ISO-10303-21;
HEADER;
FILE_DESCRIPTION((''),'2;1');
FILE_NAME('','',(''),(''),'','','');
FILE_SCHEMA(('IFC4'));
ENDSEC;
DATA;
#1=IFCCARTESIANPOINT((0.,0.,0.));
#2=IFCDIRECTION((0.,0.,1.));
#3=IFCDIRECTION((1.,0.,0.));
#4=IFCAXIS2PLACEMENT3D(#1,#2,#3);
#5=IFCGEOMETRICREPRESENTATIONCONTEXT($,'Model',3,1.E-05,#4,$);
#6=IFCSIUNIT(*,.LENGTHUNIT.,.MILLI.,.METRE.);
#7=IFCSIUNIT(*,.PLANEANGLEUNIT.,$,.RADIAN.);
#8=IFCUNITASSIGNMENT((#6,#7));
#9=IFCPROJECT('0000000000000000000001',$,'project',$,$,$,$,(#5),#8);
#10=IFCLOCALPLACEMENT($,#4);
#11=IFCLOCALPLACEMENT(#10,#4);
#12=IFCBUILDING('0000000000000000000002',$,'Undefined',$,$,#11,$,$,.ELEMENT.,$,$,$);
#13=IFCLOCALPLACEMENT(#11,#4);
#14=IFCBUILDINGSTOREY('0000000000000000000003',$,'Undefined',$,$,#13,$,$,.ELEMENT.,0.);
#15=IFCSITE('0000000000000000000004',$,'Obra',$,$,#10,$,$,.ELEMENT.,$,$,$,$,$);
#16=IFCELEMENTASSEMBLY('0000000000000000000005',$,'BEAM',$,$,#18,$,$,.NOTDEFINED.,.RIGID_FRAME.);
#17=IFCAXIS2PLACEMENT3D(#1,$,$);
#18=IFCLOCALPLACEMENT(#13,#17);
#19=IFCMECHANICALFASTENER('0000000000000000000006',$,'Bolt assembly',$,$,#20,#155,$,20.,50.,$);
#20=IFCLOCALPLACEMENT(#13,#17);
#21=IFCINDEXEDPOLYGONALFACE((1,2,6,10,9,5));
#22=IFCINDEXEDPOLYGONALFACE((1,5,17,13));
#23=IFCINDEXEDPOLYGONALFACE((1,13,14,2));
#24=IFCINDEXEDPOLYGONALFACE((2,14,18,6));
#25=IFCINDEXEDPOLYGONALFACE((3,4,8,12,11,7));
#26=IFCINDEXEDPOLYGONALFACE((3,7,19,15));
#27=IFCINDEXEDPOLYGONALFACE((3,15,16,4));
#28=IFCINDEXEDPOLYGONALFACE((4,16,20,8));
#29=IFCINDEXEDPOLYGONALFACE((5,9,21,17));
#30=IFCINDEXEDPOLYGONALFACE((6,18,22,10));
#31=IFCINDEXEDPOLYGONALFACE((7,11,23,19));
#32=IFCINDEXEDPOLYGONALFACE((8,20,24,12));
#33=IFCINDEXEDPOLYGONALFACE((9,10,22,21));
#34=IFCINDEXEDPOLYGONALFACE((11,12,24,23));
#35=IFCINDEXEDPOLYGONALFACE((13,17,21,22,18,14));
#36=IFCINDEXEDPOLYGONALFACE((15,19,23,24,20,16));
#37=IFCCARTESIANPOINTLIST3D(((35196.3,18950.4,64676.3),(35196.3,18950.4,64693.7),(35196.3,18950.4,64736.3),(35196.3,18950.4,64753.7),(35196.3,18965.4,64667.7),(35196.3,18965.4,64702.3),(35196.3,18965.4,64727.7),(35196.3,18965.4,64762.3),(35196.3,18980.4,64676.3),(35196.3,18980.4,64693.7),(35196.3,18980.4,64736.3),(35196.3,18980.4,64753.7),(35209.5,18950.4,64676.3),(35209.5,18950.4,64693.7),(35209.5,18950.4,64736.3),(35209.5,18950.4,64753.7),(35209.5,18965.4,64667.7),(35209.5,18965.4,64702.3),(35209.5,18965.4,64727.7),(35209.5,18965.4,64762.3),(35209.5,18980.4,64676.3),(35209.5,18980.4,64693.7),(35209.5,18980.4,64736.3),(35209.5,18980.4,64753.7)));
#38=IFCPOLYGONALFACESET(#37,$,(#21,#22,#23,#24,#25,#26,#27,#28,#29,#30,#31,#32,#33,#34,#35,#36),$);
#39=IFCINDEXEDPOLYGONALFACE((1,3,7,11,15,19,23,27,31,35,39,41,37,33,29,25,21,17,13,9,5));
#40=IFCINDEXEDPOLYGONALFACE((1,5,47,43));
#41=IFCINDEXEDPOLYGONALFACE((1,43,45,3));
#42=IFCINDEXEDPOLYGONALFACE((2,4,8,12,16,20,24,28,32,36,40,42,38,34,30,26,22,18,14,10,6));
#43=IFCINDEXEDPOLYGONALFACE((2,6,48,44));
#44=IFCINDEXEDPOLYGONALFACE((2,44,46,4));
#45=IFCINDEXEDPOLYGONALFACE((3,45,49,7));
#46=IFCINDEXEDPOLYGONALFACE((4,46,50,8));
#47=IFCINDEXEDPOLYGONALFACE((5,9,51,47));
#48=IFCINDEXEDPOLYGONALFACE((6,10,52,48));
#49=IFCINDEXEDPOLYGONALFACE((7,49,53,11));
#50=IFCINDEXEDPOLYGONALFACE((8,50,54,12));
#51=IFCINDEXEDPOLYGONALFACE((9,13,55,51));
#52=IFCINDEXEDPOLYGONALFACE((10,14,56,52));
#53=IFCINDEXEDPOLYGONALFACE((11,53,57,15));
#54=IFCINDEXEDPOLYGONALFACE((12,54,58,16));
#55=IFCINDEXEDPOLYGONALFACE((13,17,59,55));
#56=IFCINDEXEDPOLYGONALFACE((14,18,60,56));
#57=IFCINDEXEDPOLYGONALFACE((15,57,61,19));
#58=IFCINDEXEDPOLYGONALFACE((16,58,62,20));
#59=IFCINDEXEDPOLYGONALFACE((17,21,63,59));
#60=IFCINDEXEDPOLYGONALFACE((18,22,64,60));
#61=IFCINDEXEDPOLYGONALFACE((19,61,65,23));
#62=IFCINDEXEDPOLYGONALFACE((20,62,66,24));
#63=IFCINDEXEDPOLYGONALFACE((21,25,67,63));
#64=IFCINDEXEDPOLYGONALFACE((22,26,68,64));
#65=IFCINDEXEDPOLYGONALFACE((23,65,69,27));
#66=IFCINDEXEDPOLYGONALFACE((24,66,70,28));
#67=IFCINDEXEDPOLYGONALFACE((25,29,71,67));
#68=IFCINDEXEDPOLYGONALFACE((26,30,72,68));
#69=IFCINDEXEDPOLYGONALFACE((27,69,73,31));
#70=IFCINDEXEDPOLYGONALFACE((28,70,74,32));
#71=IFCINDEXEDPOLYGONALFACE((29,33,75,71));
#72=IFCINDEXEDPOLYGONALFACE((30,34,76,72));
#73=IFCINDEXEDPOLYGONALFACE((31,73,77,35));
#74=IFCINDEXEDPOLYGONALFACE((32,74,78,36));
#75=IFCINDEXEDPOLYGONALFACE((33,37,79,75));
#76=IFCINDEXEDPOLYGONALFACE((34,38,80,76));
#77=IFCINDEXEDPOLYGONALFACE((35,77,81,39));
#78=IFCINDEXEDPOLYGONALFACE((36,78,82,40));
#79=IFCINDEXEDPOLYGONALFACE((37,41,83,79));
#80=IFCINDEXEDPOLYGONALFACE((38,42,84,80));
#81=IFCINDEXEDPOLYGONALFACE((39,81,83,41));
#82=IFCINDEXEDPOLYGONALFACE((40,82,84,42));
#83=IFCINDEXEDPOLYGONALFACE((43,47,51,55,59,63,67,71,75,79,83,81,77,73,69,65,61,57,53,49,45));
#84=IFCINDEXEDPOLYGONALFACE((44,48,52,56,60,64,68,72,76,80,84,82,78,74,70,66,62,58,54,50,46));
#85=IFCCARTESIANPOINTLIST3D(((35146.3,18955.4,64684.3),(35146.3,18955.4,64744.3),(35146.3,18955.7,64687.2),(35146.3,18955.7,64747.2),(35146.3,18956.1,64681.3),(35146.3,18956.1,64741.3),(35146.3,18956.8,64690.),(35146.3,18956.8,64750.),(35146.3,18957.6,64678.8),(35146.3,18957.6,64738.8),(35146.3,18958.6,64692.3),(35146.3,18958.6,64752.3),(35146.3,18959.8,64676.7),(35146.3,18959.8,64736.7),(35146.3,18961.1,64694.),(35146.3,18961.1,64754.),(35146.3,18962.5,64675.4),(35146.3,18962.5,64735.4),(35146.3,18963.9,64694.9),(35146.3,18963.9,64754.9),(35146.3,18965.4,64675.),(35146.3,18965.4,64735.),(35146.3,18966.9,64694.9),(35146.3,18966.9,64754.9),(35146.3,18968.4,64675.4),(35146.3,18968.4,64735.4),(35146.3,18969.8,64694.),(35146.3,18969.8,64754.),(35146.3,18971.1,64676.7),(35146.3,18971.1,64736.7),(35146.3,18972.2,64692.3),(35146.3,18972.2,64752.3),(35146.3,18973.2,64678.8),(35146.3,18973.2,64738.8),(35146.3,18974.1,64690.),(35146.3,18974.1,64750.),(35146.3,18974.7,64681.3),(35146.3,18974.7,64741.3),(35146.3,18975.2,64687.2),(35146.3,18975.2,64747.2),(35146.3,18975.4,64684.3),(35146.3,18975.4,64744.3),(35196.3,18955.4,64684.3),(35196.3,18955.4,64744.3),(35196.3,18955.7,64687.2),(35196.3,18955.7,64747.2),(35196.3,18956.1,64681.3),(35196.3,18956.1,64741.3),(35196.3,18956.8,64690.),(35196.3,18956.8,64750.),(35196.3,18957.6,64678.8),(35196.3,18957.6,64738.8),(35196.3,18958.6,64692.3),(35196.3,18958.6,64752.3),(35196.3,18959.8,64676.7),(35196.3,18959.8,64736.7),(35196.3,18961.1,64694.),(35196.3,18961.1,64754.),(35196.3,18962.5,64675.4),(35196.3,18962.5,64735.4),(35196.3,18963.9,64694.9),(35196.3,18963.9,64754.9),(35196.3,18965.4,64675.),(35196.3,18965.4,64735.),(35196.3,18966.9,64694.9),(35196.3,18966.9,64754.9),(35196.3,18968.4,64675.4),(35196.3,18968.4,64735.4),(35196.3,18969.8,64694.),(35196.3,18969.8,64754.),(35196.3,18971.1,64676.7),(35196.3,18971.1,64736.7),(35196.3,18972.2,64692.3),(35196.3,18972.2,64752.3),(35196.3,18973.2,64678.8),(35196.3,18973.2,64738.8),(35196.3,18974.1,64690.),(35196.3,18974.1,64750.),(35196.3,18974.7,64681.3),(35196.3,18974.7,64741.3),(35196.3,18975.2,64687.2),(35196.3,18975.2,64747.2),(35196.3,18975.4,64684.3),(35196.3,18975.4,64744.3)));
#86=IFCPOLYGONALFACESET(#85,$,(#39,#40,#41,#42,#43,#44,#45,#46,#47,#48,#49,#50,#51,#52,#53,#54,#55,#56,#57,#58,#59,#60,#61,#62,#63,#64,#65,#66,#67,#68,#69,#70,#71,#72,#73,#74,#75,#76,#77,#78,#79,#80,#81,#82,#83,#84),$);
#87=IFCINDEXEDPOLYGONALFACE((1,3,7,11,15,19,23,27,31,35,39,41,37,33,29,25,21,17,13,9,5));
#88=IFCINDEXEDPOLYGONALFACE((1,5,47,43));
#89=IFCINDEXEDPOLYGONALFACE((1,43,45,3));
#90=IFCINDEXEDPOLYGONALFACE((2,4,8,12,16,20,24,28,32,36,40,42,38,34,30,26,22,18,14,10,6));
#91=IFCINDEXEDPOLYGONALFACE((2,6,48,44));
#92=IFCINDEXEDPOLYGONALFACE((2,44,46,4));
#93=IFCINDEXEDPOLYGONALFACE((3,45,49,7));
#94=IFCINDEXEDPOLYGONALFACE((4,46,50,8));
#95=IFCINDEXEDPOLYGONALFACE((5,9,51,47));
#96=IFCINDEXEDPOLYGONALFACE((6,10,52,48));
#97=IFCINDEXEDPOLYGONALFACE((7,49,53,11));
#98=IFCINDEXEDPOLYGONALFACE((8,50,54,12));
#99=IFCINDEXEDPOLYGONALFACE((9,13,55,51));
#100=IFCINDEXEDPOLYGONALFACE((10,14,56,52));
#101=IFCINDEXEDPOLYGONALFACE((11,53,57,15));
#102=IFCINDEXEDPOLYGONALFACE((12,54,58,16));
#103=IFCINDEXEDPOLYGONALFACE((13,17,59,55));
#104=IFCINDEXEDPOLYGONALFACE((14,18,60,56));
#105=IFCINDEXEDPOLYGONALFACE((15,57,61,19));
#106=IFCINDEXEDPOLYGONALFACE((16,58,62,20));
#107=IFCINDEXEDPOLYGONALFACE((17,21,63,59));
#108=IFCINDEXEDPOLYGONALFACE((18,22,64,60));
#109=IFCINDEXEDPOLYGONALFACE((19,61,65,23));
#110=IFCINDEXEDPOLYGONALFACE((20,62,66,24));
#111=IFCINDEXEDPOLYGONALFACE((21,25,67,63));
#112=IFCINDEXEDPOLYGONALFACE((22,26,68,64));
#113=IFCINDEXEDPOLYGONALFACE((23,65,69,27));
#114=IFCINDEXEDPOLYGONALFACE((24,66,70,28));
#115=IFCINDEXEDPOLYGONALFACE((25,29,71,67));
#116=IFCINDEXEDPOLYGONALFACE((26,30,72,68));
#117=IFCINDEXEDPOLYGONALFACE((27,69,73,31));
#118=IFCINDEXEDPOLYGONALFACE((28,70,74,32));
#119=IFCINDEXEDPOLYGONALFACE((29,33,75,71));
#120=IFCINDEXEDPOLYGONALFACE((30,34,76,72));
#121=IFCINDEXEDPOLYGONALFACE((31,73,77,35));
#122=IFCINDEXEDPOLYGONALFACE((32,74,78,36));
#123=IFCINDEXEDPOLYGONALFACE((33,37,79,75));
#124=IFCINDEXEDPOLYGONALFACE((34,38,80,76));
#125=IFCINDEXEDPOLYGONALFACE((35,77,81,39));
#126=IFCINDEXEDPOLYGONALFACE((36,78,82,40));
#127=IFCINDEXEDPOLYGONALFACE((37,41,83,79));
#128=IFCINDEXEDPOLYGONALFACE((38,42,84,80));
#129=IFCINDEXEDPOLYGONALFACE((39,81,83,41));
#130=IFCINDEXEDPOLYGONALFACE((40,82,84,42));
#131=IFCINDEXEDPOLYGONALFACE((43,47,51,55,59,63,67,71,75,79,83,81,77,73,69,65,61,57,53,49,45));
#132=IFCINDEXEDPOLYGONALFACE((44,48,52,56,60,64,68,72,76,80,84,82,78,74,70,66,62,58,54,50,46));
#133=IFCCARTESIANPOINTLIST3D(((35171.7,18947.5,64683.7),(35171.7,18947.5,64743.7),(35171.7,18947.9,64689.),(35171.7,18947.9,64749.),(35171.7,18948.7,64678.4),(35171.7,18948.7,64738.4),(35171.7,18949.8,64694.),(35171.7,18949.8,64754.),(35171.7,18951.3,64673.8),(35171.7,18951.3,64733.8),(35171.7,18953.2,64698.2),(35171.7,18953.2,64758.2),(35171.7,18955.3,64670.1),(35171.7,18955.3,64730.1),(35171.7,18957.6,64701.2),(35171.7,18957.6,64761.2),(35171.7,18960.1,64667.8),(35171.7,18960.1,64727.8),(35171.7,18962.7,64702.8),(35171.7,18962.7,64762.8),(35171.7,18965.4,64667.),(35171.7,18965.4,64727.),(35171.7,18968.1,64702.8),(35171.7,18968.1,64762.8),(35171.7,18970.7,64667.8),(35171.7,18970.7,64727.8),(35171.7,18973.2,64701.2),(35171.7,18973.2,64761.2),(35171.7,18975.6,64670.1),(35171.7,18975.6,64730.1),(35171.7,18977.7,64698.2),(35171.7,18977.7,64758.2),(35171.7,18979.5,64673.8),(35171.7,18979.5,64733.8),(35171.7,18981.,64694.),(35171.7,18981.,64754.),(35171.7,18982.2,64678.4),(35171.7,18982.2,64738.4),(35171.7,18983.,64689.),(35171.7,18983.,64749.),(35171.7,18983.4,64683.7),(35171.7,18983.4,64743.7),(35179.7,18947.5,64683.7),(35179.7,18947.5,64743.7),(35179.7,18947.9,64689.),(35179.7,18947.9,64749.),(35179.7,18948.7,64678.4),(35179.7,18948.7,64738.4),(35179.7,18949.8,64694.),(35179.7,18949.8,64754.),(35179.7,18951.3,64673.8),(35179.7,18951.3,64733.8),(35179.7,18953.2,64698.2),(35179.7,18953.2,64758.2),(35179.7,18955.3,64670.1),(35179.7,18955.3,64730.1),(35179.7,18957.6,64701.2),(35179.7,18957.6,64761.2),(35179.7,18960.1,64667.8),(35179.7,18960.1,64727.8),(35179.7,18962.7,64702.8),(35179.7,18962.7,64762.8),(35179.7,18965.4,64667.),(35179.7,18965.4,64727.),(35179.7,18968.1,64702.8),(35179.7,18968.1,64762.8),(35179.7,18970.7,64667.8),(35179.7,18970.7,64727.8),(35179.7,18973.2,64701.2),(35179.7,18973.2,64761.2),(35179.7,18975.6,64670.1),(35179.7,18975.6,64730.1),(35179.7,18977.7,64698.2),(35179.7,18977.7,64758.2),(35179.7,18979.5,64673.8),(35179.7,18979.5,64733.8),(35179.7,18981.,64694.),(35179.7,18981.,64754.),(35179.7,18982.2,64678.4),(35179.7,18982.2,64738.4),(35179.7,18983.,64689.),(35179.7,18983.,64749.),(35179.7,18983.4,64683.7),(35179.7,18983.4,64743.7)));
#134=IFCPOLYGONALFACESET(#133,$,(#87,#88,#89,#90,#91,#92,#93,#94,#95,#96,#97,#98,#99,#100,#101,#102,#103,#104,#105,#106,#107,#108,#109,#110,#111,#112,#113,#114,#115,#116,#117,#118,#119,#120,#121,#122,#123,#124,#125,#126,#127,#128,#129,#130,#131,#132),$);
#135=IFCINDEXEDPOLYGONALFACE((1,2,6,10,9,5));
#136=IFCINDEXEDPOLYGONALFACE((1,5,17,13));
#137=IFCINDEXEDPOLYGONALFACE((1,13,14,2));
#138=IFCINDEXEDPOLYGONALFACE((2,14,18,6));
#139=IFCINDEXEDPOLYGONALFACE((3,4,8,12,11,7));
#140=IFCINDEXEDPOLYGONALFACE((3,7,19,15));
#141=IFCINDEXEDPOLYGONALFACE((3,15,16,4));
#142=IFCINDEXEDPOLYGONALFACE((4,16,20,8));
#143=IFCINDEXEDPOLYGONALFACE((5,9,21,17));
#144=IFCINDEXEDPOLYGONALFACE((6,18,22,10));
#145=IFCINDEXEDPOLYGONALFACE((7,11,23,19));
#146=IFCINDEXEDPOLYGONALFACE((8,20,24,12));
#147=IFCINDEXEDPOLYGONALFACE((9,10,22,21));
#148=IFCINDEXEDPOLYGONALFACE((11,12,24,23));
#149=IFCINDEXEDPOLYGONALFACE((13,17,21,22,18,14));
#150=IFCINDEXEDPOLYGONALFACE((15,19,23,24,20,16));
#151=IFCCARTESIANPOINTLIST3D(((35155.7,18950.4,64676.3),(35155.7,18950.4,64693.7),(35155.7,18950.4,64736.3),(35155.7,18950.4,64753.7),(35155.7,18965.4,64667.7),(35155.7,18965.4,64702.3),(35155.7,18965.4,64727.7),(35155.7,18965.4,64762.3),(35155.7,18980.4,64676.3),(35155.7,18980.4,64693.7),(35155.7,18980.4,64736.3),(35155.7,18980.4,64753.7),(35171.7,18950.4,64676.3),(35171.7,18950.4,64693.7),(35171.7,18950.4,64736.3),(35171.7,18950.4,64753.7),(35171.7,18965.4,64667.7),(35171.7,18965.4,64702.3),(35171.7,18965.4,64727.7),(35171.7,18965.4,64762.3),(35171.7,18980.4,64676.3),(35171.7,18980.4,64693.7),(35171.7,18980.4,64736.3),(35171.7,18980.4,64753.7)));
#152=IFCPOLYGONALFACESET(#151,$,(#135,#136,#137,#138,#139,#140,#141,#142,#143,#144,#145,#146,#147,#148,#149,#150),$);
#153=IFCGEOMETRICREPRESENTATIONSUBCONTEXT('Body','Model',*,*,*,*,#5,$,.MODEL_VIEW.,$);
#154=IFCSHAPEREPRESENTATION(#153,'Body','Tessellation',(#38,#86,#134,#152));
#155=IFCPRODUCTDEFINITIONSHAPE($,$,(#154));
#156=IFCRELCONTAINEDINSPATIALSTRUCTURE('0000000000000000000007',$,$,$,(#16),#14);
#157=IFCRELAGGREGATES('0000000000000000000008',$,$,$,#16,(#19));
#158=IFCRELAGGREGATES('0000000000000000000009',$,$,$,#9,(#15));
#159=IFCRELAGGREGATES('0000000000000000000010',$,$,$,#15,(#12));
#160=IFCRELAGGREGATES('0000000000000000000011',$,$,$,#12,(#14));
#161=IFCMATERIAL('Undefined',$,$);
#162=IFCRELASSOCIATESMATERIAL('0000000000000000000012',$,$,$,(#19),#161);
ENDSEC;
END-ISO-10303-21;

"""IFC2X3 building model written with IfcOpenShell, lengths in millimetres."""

from ifc_helpers import new_model, si_unit, frame, origin_with_axes, origin_2d_with_axis, place, context, subcontext, project, spatial, polyline, circle, outline, extrude, source, transform, mapped, material, element, aggregate, save


model = new_model("IFC2X3")

# Units and contexts
model_context = context("Model", 3, precision=1e-05, world=origin_with_axes())
body_context = subcontext(model_context, "Body", "Model", "MODEL_VIEW")
ifc_project = project(units=[si_unit("LENGTHUNIT", "METRE", prefix="MILLI"), si_unit("PLANEANGLEUNIT", "RADIAN")], contexts=[model_context])

# Site, building, storey
site_placement = place(None, origin_with_axes())
site = spatial("IfcSite", under=ifc_project, at=site_placement, Name="Obra", CompositionType="ELEMENT")
building_placement = place(site_placement, origin_with_axes())
building = spatial("IfcBuilding", under=site, at=building_placement, Name="Undefined", CompositionType="ELEMENT")
storey_placement = place(building_placement, origin_with_axes())
storey = spatial("IfcBuildingStorey", under=building, at=storey_placement, Name="Undefined", CompositionType="ELEMENT", Elevation=0.0)

# Element assembly
ifc_material = material(Name="Undefined")
shared_shape_1 = source(origin_with_axes(), body_context, "Body", "SweptSolid", [
    extrude(outline(polyline([(17.3, 0.0), (8.7, 15.0), (-8.7, 15.0), (-17.3, 0.0), (-8.7, -15.0), (8.7, -15.0), (17.3, 0.0)])), frame((0.0, -26.5, 0.0), z_axis=(0.0, 1.0, 0.0), x_axis=(1.0, 0.0, 0.0)), (0.0, 0.0, 1.0), 13.2),
    extrude(circle(Radius=10.0, at=origin_2d_with_axis()), frame((0.0, -13.3, 0.0), z_axis=(0.0, 1.0, 0.0), x_axis=(1.0, 0.0, 0.0)), (0.0, 0.0, 1.0), 50.0),
    extrude(circle(Radius=18.0, at=origin_2d_with_axis()), frame((0.0, 3.3, 0.0), z_axis=(0.0, 1.0, 0.0), x_axis=(1.0, 0.0, 0.0)), (0.0, 0.0, 1.0), 8.0),
    extrude(outline(polyline([(17.3, 0.0), (8.7, 15.0), (-8.7, 15.0), (-17.3, 0.0), (-8.7, -15.0), (8.7, -15.0), (17.3, 0.0)])), frame((0.0, 11.3, 0.0), z_axis=(0.0, 1.0, 0.0), x_axis=(1.0, 0.0, 0.0)), (0.0, 0.0, 1.0), 16.0),
])
assembly_1_placement = place(storey_placement, origin_with_axes())
assembly_1 = element("IfcElementAssembly", 1, at=assembly_1_placement, inside=storey, Name="BEAM", AssemblyPlace="NOTDEFINED", PredefinedType="RIGID_FRAME")

# Mechanical fastener
mechanical_fastener_1_placement = place(assembly_1_placement, frame((35183.0, 18925.4, 64850.0), z_axis=(0.0, 1.0, 0.0), x_axis=(0.0, 0.0, -1.0)))
mechanical_fastener_1 = element("IfcMechanicalFastener", 2, at=mechanical_fastener_1_placement, material=ifc_material, Name="Bolt assembly", NominalDiameter=20.0, NominalLength=50.0, context=body_context, shape_type="MappedRepresentation", body=[
    mapped(shared_shape_1, transform((105.0, 0.0, 40.0))),
    mapped(shared_shape_1, transform((165.0, 0.0, 40.0))),
])
aggregate(assembly_1, [mechanical_fastener_1])

save(model, "model.ifc")
